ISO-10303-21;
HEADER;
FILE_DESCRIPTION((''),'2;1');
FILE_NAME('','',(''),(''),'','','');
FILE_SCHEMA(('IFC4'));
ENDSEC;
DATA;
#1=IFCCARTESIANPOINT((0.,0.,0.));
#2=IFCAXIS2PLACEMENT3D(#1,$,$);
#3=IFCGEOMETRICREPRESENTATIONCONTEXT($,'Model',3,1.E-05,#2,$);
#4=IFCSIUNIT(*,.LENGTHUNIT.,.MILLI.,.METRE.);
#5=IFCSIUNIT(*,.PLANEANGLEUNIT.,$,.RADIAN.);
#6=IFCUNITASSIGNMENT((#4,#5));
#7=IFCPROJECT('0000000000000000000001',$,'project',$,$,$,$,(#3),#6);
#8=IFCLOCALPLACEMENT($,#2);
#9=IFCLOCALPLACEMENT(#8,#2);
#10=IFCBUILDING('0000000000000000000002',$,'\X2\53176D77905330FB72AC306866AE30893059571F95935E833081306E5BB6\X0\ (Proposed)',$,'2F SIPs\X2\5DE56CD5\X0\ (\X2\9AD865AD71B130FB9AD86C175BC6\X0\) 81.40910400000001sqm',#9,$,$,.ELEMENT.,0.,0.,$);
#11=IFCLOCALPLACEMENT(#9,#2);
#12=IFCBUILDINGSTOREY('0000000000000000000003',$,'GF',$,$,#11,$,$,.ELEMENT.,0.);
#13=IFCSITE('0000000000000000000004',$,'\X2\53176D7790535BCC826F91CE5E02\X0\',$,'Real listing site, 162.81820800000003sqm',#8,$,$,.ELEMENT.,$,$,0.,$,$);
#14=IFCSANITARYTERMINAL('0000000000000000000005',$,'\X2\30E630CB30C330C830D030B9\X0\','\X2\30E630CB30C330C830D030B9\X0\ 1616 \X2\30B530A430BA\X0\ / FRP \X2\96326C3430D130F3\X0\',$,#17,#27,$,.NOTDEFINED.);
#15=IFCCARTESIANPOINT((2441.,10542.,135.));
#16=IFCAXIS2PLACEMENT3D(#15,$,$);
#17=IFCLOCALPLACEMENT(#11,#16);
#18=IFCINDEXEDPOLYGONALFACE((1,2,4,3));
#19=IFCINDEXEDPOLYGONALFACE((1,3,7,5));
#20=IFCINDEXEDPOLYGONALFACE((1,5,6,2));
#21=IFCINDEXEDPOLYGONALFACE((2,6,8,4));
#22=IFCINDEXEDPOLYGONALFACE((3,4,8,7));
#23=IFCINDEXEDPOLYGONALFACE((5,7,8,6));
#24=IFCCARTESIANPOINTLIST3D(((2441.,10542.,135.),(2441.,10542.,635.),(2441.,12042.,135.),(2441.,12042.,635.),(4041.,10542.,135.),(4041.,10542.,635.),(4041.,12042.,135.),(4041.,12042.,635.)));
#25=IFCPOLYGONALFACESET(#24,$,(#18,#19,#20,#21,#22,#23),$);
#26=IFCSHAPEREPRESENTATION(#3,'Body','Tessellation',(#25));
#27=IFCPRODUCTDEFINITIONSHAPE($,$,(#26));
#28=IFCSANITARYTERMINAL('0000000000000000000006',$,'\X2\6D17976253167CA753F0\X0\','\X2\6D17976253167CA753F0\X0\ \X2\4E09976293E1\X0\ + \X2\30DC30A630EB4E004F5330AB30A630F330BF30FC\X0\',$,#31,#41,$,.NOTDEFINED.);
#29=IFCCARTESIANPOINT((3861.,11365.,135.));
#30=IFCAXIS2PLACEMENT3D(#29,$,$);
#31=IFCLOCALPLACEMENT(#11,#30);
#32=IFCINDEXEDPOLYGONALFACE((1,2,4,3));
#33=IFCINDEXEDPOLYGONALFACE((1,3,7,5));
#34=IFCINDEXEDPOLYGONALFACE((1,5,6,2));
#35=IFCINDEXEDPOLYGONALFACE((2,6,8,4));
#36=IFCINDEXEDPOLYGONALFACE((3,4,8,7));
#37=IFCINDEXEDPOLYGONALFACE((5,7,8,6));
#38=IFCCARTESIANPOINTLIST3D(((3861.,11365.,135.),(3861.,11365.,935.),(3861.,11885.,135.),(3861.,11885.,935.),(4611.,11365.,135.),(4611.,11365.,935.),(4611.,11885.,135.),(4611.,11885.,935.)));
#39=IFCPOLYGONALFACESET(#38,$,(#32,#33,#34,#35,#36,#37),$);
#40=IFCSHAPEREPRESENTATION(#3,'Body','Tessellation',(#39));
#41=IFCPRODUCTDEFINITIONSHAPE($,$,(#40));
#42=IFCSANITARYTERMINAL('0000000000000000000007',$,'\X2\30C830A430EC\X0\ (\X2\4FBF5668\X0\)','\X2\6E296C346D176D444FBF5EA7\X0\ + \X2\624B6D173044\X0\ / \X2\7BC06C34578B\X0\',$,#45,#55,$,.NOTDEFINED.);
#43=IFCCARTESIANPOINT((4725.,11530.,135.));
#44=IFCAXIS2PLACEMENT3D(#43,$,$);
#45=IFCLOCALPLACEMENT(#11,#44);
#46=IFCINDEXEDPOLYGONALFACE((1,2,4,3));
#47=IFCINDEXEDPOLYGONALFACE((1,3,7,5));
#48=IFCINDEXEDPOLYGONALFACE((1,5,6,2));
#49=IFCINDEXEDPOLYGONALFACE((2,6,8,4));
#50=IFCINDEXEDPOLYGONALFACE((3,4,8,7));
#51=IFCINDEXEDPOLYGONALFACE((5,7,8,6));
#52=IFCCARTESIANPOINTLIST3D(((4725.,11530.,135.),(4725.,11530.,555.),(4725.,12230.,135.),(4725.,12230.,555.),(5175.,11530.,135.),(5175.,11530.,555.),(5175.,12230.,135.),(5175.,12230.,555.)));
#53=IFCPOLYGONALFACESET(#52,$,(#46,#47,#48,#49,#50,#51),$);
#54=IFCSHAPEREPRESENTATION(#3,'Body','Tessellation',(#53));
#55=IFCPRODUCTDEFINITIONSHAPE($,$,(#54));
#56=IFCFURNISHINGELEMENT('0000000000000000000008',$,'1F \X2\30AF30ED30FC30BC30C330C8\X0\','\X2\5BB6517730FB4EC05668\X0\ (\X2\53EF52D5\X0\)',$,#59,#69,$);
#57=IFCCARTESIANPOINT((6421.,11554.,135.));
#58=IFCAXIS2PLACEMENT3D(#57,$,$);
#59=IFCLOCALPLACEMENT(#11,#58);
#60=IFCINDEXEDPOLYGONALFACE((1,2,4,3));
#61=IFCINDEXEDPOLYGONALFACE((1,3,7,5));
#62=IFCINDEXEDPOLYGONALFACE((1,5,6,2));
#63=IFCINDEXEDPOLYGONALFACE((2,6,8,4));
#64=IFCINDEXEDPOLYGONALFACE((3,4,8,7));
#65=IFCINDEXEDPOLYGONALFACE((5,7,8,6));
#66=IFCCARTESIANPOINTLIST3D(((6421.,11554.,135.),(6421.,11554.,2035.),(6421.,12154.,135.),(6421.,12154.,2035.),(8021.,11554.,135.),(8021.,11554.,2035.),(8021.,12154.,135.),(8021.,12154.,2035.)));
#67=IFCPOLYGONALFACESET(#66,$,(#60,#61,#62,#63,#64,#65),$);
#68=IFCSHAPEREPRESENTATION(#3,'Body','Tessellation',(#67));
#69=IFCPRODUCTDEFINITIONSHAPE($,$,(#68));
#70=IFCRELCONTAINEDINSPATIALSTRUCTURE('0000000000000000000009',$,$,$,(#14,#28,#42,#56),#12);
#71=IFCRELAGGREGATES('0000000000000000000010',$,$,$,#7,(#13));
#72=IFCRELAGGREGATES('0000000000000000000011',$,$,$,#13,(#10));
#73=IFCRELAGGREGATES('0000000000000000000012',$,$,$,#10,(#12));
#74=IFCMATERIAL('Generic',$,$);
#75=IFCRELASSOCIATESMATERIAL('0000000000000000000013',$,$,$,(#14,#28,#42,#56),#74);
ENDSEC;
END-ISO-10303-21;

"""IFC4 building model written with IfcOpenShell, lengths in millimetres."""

from ifc_helpers import new_model, si_unit, frame, frame_2d, origin, place, context, project, spatial, rectangle, extrude, material, element, save


model = new_model("IFC4")

# Units and contexts
model_context = context("Model", 3, precision=1e-05, world=origin())
ifc_project = project(units=[si_unit("LENGTHUNIT", "METRE", prefix="MILLI"), si_unit("PLANEANGLEUNIT", "RADIAN")], contexts=[model_context])

# Site, building, storey
site_placement = place(None, origin())
site = spatial("IfcSite", under=ifc_project, at=site_placement, Name="北海道富良野市", ObjectType="Real listing site, 162.81820800000003sqm", CompositionType="ELEMENT", RefElevation=0.0)
building_placement = place(site_placement, origin())
building = spatial("IfcBuilding", under=site, at=building_placement, Name="北海道・犬と暮らす土間広めの家 (Proposed)", ObjectType="2F SIPs工法 (高断熱・高気密) 81.40910400000001sqm", CompositionType="ELEMENT", ElevationOfRefHeight=0.0, ElevationOfTerrain=0.0)
storey_placement = place(building_placement, origin())
storey = spatial("IfcBuildingStorey", under=building, at=storey_placement, Name="GF", CompositionType="ELEMENT", Elevation=0.0)

# Shared definitions
ifc_material_1 = material(Name="Generic")

# Sanitary terminals
sanitary_terminal_1_placement = place(storey_placement, frame((2441.0, 10542.0, 135.0)))
element("IfcSanitaryTerminal", 1, at=sanitary_terminal_1_placement, inside=storey, material=ifc_material_1, Name="ユニットバス", Description="ユニットバス 1616 サイズ / FRP 防水パン", PredefinedType="NOTDEFINED", context=model_context, shape_type="SweptSolid", body=[
    extrude(rectangle(XDim=1600.0, YDim=1500.0, at=frame_2d((800.0, 750.0))), frame((2441.0, 10542.0, 135.0)), (0.0, 0.0, 1.0), 500.0),
])
sanitary_terminal_2_placement = place(storey_placement, frame((3861.0, 11365.0, 135.0)))
element("IfcSanitaryTerminal", 2, at=sanitary_terminal_2_placement, inside=storey, material=ifc_material_1, Name="洗面化粧台", Description="洗面化粧台 三面鏡 + ボウル一体カウンター", PredefinedType="NOTDEFINED", context=model_context, shape_type="SweptSolid", body=[
    extrude(rectangle(XDim=750.0, YDim=520.0, at=frame_2d((375.0, 260.0))), frame((3861.0, 11365.0, 135.0)), (0.0, 0.0, 1.0), 800.0),
])
sanitary_terminal_3_placement = place(storey_placement, frame((4725.0, 11530.0, 135.0)))
element("IfcSanitaryTerminal", 3, at=sanitary_terminal_3_placement, inside=storey, material=ifc_material_1, Name="トイレ (便器)", Description="温水洗浄便座 + 手洗い / 節水型", PredefinedType="NOTDEFINED", context=model_context, shape_type="SweptSolid", body=[
    extrude(rectangle(XDim=450.0, YDim=700.0, at=frame_2d((225.0, 350.0))), frame((4725.0, 11530.0, 135.0)), (0.0, 0.0, 1.0), 420.0),
])

# Furnishing element
furnishing_placement = place(storey_placement, frame((6421.0, 11554.0, 135.0)))
element("IfcFurnishingElement", 4, at=furnishing_placement, inside=storey, material=ifc_material_1, Name="1F クローゼット", Description="家具・什器 (可動)", context=model_context, shape_type="SweptSolid", body=[
    extrude(rectangle(XDim=1600.0, YDim=600.0, at=frame_2d((800.0, 300.0))), frame((6421.0, 11554.0, 135.0)), (0.0, 0.0, 1.0), 1900.0),
])

save(model, "model.ifc")
